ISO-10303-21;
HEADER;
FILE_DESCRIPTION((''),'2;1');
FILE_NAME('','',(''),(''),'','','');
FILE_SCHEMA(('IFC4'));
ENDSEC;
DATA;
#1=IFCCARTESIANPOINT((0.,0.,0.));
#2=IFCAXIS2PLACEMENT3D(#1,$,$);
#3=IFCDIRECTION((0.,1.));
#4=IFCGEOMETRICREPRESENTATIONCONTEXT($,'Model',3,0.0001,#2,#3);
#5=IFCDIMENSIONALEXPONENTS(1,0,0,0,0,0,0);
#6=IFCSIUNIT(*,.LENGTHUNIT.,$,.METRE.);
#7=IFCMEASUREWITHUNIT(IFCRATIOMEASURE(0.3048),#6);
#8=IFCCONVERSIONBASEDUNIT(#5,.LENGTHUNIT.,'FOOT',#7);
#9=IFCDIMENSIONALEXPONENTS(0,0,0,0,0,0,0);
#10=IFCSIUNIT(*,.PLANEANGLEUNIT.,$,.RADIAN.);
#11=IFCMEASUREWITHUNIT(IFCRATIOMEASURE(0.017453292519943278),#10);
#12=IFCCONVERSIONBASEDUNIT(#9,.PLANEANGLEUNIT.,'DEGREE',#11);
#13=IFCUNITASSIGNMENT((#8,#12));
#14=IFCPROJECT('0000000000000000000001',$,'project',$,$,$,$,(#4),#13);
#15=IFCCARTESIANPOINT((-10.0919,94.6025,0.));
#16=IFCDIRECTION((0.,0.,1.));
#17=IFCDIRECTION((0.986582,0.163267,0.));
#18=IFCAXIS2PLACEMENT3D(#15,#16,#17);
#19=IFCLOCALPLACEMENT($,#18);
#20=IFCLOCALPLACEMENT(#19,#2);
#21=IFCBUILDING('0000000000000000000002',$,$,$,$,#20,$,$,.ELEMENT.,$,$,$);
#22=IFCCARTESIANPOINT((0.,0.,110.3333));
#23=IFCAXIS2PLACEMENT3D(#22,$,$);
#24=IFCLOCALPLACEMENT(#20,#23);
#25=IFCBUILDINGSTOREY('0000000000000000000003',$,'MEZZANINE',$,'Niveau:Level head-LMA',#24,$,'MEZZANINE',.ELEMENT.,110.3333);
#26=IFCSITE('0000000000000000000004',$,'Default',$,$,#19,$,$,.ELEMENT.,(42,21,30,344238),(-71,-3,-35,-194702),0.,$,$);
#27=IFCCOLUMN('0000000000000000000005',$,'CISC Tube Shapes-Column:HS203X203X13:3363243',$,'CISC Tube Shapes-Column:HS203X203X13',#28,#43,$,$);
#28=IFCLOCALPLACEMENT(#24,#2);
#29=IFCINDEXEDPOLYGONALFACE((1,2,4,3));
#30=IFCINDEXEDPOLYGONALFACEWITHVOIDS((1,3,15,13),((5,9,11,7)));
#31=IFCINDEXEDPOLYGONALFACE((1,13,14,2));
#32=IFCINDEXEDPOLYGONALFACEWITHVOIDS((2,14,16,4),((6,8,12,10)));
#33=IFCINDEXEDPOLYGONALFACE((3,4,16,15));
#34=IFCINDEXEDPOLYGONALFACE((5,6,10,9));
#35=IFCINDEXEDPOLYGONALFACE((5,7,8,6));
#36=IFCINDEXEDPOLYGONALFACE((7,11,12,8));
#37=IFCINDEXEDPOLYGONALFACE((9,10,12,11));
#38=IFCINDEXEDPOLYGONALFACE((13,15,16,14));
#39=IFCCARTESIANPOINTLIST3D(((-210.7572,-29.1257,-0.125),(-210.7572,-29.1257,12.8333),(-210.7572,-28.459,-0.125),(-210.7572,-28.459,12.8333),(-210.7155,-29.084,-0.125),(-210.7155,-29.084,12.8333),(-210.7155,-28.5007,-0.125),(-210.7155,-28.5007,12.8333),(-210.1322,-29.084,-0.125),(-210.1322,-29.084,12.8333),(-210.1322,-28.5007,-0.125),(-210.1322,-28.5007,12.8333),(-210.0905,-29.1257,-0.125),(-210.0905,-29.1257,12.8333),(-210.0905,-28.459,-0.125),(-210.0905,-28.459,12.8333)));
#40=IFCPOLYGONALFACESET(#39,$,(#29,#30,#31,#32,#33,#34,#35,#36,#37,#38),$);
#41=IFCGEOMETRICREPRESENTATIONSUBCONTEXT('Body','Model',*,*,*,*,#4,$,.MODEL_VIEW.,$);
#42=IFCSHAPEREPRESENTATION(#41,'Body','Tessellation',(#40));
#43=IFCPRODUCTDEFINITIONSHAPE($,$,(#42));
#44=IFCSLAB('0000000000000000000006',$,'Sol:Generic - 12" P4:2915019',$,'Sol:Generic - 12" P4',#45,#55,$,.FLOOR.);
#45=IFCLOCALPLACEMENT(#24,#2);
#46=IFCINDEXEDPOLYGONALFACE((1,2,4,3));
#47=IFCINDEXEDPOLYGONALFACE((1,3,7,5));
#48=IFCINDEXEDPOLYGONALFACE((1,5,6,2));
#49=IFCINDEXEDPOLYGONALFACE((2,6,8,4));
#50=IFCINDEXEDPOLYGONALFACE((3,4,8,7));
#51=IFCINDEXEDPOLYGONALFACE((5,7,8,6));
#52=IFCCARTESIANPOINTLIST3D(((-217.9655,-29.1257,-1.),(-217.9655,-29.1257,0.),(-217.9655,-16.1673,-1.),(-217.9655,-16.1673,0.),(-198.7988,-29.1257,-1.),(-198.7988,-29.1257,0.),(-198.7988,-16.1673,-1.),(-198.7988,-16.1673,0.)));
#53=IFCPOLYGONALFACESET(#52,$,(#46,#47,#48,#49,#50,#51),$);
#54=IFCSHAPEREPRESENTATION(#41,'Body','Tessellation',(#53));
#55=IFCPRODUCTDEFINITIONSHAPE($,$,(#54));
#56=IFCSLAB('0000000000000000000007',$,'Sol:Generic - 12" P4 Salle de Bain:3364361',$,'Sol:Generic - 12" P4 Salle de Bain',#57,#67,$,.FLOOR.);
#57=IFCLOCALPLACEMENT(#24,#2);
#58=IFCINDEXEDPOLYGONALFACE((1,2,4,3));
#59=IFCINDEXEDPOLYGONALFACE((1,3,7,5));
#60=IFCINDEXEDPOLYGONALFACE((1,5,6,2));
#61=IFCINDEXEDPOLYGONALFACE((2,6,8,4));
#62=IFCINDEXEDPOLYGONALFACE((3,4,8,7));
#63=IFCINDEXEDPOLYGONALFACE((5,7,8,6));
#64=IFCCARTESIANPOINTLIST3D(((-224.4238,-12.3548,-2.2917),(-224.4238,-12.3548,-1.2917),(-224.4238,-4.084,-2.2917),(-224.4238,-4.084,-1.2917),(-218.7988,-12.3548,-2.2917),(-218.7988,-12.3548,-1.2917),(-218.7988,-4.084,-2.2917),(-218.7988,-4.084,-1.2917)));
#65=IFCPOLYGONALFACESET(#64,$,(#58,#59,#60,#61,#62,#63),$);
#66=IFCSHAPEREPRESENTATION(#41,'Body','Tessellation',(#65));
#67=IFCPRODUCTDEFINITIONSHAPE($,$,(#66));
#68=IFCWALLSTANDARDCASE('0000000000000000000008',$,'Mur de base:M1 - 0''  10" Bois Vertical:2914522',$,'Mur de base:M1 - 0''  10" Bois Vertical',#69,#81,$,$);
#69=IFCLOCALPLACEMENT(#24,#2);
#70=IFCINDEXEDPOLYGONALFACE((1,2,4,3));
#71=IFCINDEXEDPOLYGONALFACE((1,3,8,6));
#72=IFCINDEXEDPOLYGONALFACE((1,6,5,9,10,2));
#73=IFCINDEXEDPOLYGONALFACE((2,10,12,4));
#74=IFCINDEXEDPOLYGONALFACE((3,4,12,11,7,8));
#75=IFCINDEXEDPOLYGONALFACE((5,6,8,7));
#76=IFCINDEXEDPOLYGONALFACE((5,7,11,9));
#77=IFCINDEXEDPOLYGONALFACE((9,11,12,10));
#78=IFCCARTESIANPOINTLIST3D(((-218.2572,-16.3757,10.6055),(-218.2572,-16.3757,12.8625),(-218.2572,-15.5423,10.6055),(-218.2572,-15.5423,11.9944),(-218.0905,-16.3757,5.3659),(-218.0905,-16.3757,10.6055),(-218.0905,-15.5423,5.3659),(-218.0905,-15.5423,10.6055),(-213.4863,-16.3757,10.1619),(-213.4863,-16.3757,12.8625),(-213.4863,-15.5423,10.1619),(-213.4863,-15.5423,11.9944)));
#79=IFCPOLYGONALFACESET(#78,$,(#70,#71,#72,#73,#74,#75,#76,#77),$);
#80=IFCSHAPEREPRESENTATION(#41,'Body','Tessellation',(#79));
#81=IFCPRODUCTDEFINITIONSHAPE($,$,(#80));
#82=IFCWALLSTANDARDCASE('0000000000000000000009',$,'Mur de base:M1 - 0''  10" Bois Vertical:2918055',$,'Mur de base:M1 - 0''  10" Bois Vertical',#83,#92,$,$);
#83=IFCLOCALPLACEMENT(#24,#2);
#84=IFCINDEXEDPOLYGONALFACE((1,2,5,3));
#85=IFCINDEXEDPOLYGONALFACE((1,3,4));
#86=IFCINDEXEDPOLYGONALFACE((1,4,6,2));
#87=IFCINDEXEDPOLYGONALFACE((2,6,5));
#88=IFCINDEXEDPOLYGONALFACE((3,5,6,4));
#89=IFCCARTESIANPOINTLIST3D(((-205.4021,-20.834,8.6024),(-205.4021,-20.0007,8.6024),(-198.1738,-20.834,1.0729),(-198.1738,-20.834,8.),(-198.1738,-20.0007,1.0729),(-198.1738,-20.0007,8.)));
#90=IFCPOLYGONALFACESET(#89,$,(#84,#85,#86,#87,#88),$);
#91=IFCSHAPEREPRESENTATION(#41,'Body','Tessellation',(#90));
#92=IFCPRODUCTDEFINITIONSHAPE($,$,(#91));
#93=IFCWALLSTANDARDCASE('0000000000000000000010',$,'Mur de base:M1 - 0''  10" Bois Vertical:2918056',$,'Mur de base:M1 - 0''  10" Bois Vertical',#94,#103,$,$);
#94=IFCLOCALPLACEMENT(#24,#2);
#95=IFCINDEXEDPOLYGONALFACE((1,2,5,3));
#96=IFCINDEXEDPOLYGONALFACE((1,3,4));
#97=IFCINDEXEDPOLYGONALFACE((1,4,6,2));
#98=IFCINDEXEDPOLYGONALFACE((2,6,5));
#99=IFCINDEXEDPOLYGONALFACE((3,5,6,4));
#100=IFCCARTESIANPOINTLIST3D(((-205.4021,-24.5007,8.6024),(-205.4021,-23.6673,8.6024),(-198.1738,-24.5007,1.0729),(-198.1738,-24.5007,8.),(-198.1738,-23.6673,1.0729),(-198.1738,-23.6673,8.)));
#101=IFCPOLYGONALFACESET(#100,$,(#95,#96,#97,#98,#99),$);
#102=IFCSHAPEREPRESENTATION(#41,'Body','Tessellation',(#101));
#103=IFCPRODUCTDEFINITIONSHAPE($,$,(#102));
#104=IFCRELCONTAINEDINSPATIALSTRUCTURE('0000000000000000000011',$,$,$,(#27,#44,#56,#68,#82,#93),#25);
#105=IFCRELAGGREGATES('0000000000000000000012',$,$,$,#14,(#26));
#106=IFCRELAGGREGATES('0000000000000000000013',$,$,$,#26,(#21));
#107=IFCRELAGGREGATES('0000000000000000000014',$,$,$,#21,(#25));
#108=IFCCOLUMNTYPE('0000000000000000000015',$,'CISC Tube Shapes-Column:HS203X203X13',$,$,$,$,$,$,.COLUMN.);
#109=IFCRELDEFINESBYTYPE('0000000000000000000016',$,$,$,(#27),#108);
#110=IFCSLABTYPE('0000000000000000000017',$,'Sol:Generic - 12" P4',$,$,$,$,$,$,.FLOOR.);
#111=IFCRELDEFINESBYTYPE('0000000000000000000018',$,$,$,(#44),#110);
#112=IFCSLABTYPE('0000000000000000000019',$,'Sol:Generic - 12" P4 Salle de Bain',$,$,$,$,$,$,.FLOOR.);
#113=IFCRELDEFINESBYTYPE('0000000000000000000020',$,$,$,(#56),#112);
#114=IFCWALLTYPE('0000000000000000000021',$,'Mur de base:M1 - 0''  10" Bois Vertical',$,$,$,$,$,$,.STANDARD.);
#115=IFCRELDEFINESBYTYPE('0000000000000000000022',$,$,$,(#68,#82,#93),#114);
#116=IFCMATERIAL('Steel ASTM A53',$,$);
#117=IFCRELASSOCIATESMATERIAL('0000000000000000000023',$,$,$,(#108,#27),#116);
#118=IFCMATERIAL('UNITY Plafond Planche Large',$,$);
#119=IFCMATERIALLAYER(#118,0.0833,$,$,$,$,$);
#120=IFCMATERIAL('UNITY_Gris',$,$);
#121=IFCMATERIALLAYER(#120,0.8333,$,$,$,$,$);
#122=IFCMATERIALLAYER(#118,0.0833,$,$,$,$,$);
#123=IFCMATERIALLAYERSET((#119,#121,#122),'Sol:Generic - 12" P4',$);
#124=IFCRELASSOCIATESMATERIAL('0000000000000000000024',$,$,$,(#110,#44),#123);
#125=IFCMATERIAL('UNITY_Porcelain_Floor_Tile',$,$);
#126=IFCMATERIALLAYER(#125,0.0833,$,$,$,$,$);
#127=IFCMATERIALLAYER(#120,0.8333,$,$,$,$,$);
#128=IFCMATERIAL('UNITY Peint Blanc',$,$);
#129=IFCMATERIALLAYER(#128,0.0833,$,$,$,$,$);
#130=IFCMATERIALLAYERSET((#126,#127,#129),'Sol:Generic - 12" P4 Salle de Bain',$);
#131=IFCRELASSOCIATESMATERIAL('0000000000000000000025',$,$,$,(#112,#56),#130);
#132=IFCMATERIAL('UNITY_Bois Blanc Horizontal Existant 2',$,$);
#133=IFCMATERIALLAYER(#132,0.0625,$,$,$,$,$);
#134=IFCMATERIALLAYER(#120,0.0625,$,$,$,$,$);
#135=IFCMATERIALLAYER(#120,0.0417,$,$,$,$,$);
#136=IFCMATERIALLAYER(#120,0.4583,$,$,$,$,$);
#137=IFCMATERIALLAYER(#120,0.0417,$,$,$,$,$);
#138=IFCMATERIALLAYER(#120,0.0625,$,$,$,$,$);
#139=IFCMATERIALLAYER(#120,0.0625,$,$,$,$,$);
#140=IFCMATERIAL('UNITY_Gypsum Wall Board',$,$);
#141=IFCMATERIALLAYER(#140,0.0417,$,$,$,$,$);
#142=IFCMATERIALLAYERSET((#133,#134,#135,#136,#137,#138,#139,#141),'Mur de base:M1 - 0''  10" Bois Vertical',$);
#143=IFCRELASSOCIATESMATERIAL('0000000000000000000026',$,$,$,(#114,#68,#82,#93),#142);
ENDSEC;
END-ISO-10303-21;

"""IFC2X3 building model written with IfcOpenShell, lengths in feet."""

from ifc_helpers import new_model, entity, si_unit, converted_unit, direction, frame, frame_2d, origin, origin_2d_with_axis, place, context, subcontext, project, spatial, polyline, rectangle, outline, extrude, clip, bounded_halfspace, source, transform, mapped, material, layer, layer_set, layer_usage, type_object, type_shapes, element, save


model = new_model("IFC2X3")

# Units and contexts
model_context = context("Model", 3, precision=0.0001, world=origin(), true_north=direction((0.0, 1.0)))
body_context = subcontext(model_context, "Body", "Model", "MODEL_VIEW")
ifc_project = project(units=[converted_unit("LENGTHUNIT", "FOOT", entity("IfcRatioMeasure", 0.3048), si_unit("LENGTHUNIT", "METRE"), dimensions=[1, 0, 0, 0, 0, 0, 0]), converted_unit("PLANEANGLEUNIT", "DEGREE", entity("IfcRatioMeasure", 0.017453292519943278), si_unit("PLANEANGLEUNIT", "RADIAN"), dimensions=[0, 0, 0, 0, 0, 0, 0])], contexts=[model_context])

# Site, building, storey
site_placement = place(None, frame((-10.0919, 94.6025, 0.0), z_axis=(0.0, 0.0, 1.0), x_axis=(0.986582, 0.163267, 0.0)))
site = spatial("IfcSite", under=ifc_project, at=site_placement, Name="Default", CompositionType="ELEMENT", RefLatitude=(42, 21, 30, 344238), RefLongitude=(-71, -3, -35, -194702), RefElevation=0.0)
building_placement = place(site_placement, origin())
building = spatial("IfcBuilding", under=site, at=building_placement, CompositionType="ELEMENT")
storey_placement = place(building_placement, frame((0.0, 0.0, 110.3333)))
storey = spatial("IfcBuildingStorey", under=building, at=storey_placement, Name="MEZZANINE", ObjectType="Niveau:Level head-LMA", LongName="MEZZANINE", CompositionType="ELEMENT", Elevation=110.3333)

# Column
ifc_material_1 = material(Name="Steel ASTM A53")
column_type = type_object("IfcColumnType", Name="CISC Tube Shapes-Column:HS203X203X13", PredefinedType="COLUMN", material=ifc_material_1)
shared_shape_1 = source(origin(), body_context, "Body", "SweptSolid", [
    extrude(outline(polyline([(-0.3333, -0.3333), (0.3333, -0.3333), (0.3333, 0.3333), (-0.3333, 0.3333), (-0.3333, -0.3333)]), holes=[polyline([(-0.2917, -0.2917), (-0.2917, 0.2917), (0.2917, 0.2917), (0.2917, -0.2917), (-0.2917, -0.2917)])]), frame((0.0, 0.0, 110.2083), z_axis=(0.0, 0.0, 1.0), x_axis=(-1.0, 0.0, 0.0)), (0.0, 0.0, 1.0), 12.9583),
])
type_shapes(column_type, [shared_shape_1])
column_placement = place(storey_placement, frame((-210.4238, -28.7923, -110.3333)))
element("IfcColumn", 1, at=column_placement, inside=storey, type_object=column_type, material=ifc_material_1, Name="CISC Tube Shapes-Column:HS203X203X13:3363243", ObjectType="CISC Tube Shapes-Column:HS203X203X13", context=body_context, shape_type="MappedRepresentation", body=[
    mapped(shared_shape_1, transform((0.0, 0.0, 0.0), scale=1.0)),
])

# Slabs
ifc_material_2 = material(Name="UNITY Plafond Planche Large")
ifc_layer_1 = layer(ifc_material_2, 0.0833)
ifc_material_3 = material(Name="UNITY_Gris")
ifc_layer_2 = layer(ifc_material_3, 0.8333)
ifc_layer_3 = layer(ifc_material_2, 0.0833)
ifc_layer_set_1 = layer_set([ifc_layer_1, ifc_layer_2, ifc_layer_3], Name="Sol:Generic - 12\" P4")
ifc_layer_usage_1 = layer_usage(ifc_layer_set_1, "AXIS3", "POSITIVE", 0.0)
slab_type_1 = type_object("IfcSlabType", Name="Sol:Generic - 12\" P4", PredefinedType="FLOOR", material=ifc_layer_set_1)
slab_1_placement = place(storey_placement, origin())
element("IfcSlab", 2, at=slab_1_placement, inside=storey, type_object=slab_type_1, material=ifc_layer_usage_1, Name="Sol:Generic - 12\" P4:2915019", ObjectType="Sol:Generic - 12\" P4", PredefinedType="FLOOR", context=body_context, shape_type="SweptSolid", body=[
    extrude(rectangle(XDim=12.9583, YDim=19.1666, at=origin_2d_with_axis()), frame((-208.3822, -22.6465, 0.0), z_axis=(0.0, 0.0, -1.0), x_axis=(0.0, 1.0, 0.0)), (0.0, 0.0, 1.0), 1.0),
])
ifc_material_4 = material(Name="UNITY Peint Blanc")
ifc_material_5 = material(Name="UNITY_Porcelain_Floor_Tile")
ifc_layer_4 = layer(ifc_material_5, 0.0833)
ifc_layer_5 = layer(ifc_material_3, 0.8333)
ifc_layer_6 = layer(ifc_material_4, 0.0833)
ifc_layer_set_2 = layer_set([ifc_layer_4, ifc_layer_5, ifc_layer_6], Name="Sol:Generic - 12\" P4 Salle de Bain")
ifc_layer_usage_2 = layer_usage(ifc_layer_set_2, "AXIS3", "POSITIVE", 0.0)
slab_type_2 = type_object("IfcSlabType", Name="Sol:Generic - 12\" P4 Salle de Bain", PredefinedType="FLOOR", material=ifc_layer_set_2)
slab_2_placement = place(storey_placement, origin())
element("IfcSlab", 3, at=slab_2_placement, inside=storey, type_object=slab_type_2, material=ifc_layer_usage_2, Name="Sol:Generic - 12\" P4 Salle de Bain:3364361", ObjectType="Sol:Generic - 12\" P4 Salle de Bain", PredefinedType="FLOOR", context=body_context, shape_type="SweptSolid", body=[
    extrude(rectangle(XDim=8.2708, YDim=5.625, at=frame_2d((0.0, 0.0), x_axis=(1.0, 0.0))), frame((-221.6113, -8.2194, -1.2917), z_axis=(0.0, 0.0, -1.0), x_axis=(0.0, 1.0, 0.0)), (0.0, 0.0, 1.0), 1.0),
])

# Shared definitions
ifc_material_6 = material(Name="UNITY_Bois Blanc Horizontal Existant 2")
ifc_material_7 = material(Name="UNITY_Gypsum Wall Board")

# Wall
ifc_layer_7 = layer(ifc_material_6, 0.0625)
ifc_layer_8 = layer(ifc_material_3, 0.0625)
ifc_layer_9 = layer(ifc_material_3, 0.0417)
ifc_layer_10 = layer(ifc_material_3, 0.4583)
ifc_layer_11 = layer(ifc_material_3, 0.0417)
ifc_layer_12 = layer(ifc_material_3, 0.0625)
ifc_layer_13 = layer(ifc_material_3, 0.0625)
ifc_layer_14 = layer(ifc_material_7, 0.0417)
ifc_layer_set_3 = layer_set([ifc_layer_7, ifc_layer_8, ifc_layer_9, ifc_layer_10, ifc_layer_11, ifc_layer_12, ifc_layer_13, ifc_layer_14], Name="Mur de base:M1 - 0'  10\" Bois Vertical")
ifc_layer_usage_3 = layer_usage(ifc_layer_set_3, "AXIS2", "NEGATIVE", 0.4167)
wall_type_1 = type_object("IfcWallType", Name="Mur de base:M1 - 0'  10\" Bois Vertical", PredefinedType="STANDARD", material=ifc_layer_set_3)
wall_1_placement = place(storey_placement, frame((-218.2572, -15.959, 5.3659)))
element("IfcWallStandardCase", 4, at=wall_1_placement, inside=storey, type_object=wall_type_1, material=ifc_layer_usage_3, Name="Mur de base:M1 - 0'  10\" Bois Vertical:2914522", ObjectType="Mur de base:M1 - 0'  10\" Bois Vertical", context=body_context, shape_type="Clipping", body=[
    clip(clip(clip(clip(extrude(rectangle(XDim=4.7708, YDim=0.8333, at=frame_2d((2.3854, 0.0), x_axis=(-1.0, 0.0))), origin(), (0.0, 0.0, 1.0), 7.4966), bounded_halfspace(frame((0.0, -0.4167, 7.4966), z_axis=(0.0, 0.721387, 0.692532), x_axis=(-1.0, 0.0, 0.0)), False, frame((0.0, -0.4167, 7.4966)), polyline([(0.0, 0.0), (4.7708, 0.0), (4.7708, 0.8333), (0.0, 0.8333), (0.0, 0.0)]))), bounded_halfspace(frame((4.7708, 0.4167, 4.796), z_axis=(-0.721387, 0.0, 0.692532), x_axis=(0.0, -1.0, 0.0)), True, frame((4.7708, 0.4167, 4.796)), polyline([(0.0, 0.0), (-4.6042, 0.0), (-4.6042, -0.8333), (0.0, -0.8333), (0.0, 0.0)]))), bounded_halfspace(frame((0.1667, 0.4167, 5.2396)), True, frame((0.1667, 0.4167, 5.2396)), polyline([(0.0, 0.0), (-0.1667, 0.0), (-0.1667, -0.8333), (0.0, -0.8333), (0.0, 0.0)]))), bounded_halfspace(frame((0.1667, -0.4167, 5.2396), z_axis=(1.0, 0.0, 0.0), x_axis=(0.0, 0.0, -1.0)), True, frame((0.1667, -0.4167, 5.2396), z_axis=(1.0, 0.0, 0.0), x_axis=(0.0, 0.0, -1.0)), polyline([(0.0, 0.0), (5.2396, 0.0), (5.2396, 0.8333), (0.0, 0.8333), (0.0, 0.0)]))),
])

# Walls, openings
ifc_layer_usage_4 = layer_usage(ifc_layer_set_3, "AXIS2", "POSITIVE", -0.4167)
wall_2_placement = place(storey_placement, frame((-198.1738, -20.4173, 1.0729), z_axis=(0.0, 0.0, 1.0), x_axis=(-1.0, 0.0, 0.0)))
wall_2 = element("IfcWallStandardCase", 5, at=wall_2_placement, inside=storey, type_object=wall_type_1, material=ifc_layer_usage_4, Name="Mur de base:M1 - 0'  10\" Bois Vertical:2918055", ObjectType="Mur de base:M1 - 0'  10\" Bois Vertical", context=body_context, shape_type="Clipping", body=[
    clip(clip(extrude(rectangle(XDim=7.2283, YDim=0.8333, at=frame_2d((3.6141, 0.0), x_axis=(-1.0, 0.0))), origin(), (0.0, 0.0, 1.0), 7.5294), bounded_halfspace(frame((0.0, -0.4167, 6.9271), z_axis=(-0.083045, 0.0, 0.996546), x_axis=(0.0, -1.0, 0.0)), False, frame((0.0, -0.4167, 6.9271)), polyline([(0.0, 0.0), (7.2283, 0.0), (7.2283, 0.8333), (0.8333, 0.8333), (0.0, 0.8333), (0.0, 0.0)]))), bounded_halfspace(frame((7.2283, -0.4167, 7.5294), z_axis=(-0.721387, 0.0, 0.692532), x_axis=(0.0, -1.0, 0.0)), True, frame((7.2283, -0.4167, 7.5294)), polyline([(0.0, 0.0), (0.0, 0.8333), (-7.2283, 0.8333), (-7.2283, 0.0), (0.0, 0.0)]))),
])
opening_1_placement = place(wall_2_placement, origin())
element("IfcOpeningElement", 6, at=opening_1_placement, cuts=wall_2, ObjectType="Opening", context=body_context, shape_type="SweptSolid", body=[
    extrude(rectangle(XDim=6.5833, YDim=0.8333, at=frame_2d((0.0, 0.0), x_axis=(0.0, 1.0))), frame((0.4167, 0.4167, 3.6354), z_axis=(0.0, 1.0, 0.0), x_axis=(1.0, 0.0, 0.0)), (0.0, 0.0, 1.0), 2.8333),
])
ifc_layer_usage_5 = layer_usage(ifc_layer_set_3, "AXIS2", "NEGATIVE", 0.4167)
wall_3_placement = place(storey_placement, frame((-198.1738, -24.084, 1.0729), z_axis=(0.0, 0.0, 1.0), x_axis=(-1.0, 0.0, 0.0)))
wall_3 = element("IfcWallStandardCase", 7, at=wall_3_placement, inside=storey, type_object=wall_type_1, material=ifc_layer_usage_5, Name="Mur de base:M1 - 0'  10\" Bois Vertical:2918056", ObjectType="Mur de base:M1 - 0'  10\" Bois Vertical", context=body_context, shape_type="Clipping", body=[
    clip(clip(extrude(rectangle(XDim=7.2283, YDim=0.8333, at=frame_2d((3.6141, 0.0), x_axis=(-1.0, 0.0))), origin(), (0.0, 0.0, 1.0), 7.5294), bounded_halfspace(frame((0.0, 0.4167, 6.9271), z_axis=(-0.083045, 0.0, 0.996546), x_axis=(0.0, -1.0, 0.0)), False, frame((0.0, 0.4167, 6.9271)), polyline([(0.0, 0.0), (0.0, -0.8333), (0.8333, -0.8333), (7.2283, -0.8333), (7.2283, 0.0), (0.0, 0.0)]))), bounded_halfspace(frame((7.2283, -0.4167, 7.5294), z_axis=(-0.721387, 0.0, 0.692532), x_axis=(0.0, -1.0, 0.0)), True, frame((7.2283, -0.4167, 7.5294)), polyline([(0.0, 0.0), (0.0, 0.8333), (-7.2283, 0.8333), (-7.2283, 0.0), (0.0, 0.0)]))),
])
opening_2_placement = place(wall_3_placement, origin())
element("IfcOpeningElement", 8, at=opening_2_placement, cuts=wall_3, ObjectType="Opening", context=body_context, shape_type="SweptSolid", body=[
    extrude(rectangle(XDim=6.5833, YDim=0.8333, at=frame_2d((0.0, 0.0), x_axis=(0.0, 1.0))), frame((0.4167, -3.25, 3.6354), z_axis=(0.0, 1.0, 0.0), x_axis=(1.0, 0.0, 0.0)), (0.0, 0.0, 1.0), 2.8333),
])

save(model, "model.ifc")
